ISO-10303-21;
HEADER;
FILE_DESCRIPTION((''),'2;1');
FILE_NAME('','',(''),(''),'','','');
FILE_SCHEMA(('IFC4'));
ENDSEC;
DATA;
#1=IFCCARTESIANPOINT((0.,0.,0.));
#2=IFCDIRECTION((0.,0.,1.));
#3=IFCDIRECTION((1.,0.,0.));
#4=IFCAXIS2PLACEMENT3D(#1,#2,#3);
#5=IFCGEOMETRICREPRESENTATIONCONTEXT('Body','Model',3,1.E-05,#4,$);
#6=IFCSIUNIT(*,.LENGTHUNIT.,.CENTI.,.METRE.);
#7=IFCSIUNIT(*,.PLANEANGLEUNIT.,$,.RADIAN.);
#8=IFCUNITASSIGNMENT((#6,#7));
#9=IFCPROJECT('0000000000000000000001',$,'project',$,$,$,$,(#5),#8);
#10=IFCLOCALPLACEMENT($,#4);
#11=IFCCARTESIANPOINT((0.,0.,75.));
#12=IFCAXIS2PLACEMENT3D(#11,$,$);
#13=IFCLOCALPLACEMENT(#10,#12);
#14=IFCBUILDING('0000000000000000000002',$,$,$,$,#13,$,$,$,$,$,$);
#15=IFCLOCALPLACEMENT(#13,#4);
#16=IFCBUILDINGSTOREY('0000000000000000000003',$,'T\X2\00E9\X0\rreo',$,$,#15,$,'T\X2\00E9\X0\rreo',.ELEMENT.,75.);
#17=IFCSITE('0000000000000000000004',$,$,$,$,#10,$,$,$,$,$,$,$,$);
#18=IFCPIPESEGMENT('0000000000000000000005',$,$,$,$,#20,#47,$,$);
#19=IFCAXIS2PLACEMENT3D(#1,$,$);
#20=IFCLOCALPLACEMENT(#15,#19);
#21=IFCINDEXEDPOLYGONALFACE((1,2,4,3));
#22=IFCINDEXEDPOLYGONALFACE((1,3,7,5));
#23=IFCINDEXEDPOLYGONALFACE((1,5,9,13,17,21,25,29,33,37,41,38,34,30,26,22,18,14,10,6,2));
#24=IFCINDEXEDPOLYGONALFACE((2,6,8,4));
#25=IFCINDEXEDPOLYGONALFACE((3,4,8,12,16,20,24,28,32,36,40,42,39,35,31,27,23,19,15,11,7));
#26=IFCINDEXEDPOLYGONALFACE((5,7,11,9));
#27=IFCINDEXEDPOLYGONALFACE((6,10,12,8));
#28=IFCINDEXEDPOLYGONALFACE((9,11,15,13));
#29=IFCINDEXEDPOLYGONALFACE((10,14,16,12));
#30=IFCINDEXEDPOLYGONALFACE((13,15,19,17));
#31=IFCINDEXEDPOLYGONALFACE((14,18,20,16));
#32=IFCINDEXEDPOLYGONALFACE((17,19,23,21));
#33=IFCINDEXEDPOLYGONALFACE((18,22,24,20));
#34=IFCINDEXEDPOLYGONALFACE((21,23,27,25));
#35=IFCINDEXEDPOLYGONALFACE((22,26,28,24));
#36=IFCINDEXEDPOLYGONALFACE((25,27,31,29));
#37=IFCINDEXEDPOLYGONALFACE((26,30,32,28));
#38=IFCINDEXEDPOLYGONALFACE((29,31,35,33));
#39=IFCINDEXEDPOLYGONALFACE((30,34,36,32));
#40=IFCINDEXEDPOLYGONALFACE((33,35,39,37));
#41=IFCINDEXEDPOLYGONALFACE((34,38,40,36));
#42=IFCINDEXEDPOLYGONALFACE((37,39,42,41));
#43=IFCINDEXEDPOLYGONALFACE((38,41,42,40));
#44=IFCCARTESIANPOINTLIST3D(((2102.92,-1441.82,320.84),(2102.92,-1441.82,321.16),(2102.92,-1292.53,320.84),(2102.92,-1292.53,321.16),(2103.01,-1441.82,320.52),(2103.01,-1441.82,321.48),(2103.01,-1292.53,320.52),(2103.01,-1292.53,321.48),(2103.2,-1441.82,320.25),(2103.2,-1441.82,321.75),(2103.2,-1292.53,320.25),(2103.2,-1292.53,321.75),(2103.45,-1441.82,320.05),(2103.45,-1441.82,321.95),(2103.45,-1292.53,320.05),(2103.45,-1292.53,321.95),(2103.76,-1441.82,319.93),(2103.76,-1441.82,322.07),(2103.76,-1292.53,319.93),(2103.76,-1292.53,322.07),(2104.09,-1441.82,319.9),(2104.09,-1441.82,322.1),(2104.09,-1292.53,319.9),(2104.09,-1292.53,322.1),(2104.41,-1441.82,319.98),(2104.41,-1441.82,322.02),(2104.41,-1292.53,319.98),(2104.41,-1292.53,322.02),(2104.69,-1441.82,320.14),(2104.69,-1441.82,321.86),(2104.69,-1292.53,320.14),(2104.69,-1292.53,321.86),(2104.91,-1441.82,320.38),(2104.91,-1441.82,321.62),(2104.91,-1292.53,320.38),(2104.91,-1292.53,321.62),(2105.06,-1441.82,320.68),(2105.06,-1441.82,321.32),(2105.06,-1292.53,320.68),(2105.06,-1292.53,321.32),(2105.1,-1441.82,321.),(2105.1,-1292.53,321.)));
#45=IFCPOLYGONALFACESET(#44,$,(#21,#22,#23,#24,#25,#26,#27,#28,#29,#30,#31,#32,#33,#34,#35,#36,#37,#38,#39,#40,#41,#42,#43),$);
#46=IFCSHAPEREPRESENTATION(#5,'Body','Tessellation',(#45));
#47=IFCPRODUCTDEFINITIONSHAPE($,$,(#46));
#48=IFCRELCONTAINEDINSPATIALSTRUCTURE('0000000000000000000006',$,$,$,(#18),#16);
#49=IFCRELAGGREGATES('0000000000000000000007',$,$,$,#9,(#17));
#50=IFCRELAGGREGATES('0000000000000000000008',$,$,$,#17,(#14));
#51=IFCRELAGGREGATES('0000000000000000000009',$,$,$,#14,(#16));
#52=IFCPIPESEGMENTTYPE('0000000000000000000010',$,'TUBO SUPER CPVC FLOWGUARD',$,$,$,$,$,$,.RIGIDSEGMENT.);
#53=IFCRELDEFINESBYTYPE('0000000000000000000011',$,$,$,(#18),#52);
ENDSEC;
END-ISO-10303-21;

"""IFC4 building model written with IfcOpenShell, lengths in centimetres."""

from ifc_helpers import new_model, si_unit, frame, origin_with_axes, origin_2d_with_axis, place, context, project, spatial, circle, extrude, type_object, element, save


model = new_model("IFC4")

# Units and contexts
model_context = context("Model", 3, precision=1e-05, world=origin_with_axes(), identifier="Body")
ifc_project = project(units=[si_unit("LENGTHUNIT", "METRE", prefix="CENTI"), si_unit("PLANEANGLEUNIT", "RADIAN")], contexts=[model_context])

# Site, building, storey
site_placement = place(None, origin_with_axes())
site = spatial("IfcSite", under=ifc_project, at=site_placement)
building_placement = place(site_placement, frame((0.0, 0.0, 75.0)))
building = spatial("IfcBuilding", under=site, at=building_placement)
storey_placement = place(building_placement, origin_with_axes())
storey = spatial("IfcBuildingStorey", under=building, at=storey_placement, Name="Térreo", LongName="Térreo", CompositionType="ELEMENT", Elevation=75.0)

# Pipe segment
pipe_segment_type_1 = type_object("IfcPipeSegmentType", Name="TUBO SUPER CPVC FLOWGUARD", PredefinedType="RIGIDSEGMENT")
pipe_segment_1_placement = place(storey_placement, frame((2104.0, -1367.18, 322.1), z_axis=(0.0, 0.0, 1.0), x_axis=(1.0, 0.0, 0.0)))
element("IfcPipeSegment", 1, at=pipe_segment_1_placement, inside=storey, type_object=pipe_segment_type_1, context=model_context, shape_type="SolidModel", body=[
    extrude(circle(Radius=1.1, at=origin_2d_with_axis()), frame((0.0, -74.65, -1.1), z_axis=(0.0, 1.0, 0.0), x_axis=(1.0, 0.0, 0.0)), (0.0, 0.0, 1.0), 149.3),
])

save(model, "model.ifc")
